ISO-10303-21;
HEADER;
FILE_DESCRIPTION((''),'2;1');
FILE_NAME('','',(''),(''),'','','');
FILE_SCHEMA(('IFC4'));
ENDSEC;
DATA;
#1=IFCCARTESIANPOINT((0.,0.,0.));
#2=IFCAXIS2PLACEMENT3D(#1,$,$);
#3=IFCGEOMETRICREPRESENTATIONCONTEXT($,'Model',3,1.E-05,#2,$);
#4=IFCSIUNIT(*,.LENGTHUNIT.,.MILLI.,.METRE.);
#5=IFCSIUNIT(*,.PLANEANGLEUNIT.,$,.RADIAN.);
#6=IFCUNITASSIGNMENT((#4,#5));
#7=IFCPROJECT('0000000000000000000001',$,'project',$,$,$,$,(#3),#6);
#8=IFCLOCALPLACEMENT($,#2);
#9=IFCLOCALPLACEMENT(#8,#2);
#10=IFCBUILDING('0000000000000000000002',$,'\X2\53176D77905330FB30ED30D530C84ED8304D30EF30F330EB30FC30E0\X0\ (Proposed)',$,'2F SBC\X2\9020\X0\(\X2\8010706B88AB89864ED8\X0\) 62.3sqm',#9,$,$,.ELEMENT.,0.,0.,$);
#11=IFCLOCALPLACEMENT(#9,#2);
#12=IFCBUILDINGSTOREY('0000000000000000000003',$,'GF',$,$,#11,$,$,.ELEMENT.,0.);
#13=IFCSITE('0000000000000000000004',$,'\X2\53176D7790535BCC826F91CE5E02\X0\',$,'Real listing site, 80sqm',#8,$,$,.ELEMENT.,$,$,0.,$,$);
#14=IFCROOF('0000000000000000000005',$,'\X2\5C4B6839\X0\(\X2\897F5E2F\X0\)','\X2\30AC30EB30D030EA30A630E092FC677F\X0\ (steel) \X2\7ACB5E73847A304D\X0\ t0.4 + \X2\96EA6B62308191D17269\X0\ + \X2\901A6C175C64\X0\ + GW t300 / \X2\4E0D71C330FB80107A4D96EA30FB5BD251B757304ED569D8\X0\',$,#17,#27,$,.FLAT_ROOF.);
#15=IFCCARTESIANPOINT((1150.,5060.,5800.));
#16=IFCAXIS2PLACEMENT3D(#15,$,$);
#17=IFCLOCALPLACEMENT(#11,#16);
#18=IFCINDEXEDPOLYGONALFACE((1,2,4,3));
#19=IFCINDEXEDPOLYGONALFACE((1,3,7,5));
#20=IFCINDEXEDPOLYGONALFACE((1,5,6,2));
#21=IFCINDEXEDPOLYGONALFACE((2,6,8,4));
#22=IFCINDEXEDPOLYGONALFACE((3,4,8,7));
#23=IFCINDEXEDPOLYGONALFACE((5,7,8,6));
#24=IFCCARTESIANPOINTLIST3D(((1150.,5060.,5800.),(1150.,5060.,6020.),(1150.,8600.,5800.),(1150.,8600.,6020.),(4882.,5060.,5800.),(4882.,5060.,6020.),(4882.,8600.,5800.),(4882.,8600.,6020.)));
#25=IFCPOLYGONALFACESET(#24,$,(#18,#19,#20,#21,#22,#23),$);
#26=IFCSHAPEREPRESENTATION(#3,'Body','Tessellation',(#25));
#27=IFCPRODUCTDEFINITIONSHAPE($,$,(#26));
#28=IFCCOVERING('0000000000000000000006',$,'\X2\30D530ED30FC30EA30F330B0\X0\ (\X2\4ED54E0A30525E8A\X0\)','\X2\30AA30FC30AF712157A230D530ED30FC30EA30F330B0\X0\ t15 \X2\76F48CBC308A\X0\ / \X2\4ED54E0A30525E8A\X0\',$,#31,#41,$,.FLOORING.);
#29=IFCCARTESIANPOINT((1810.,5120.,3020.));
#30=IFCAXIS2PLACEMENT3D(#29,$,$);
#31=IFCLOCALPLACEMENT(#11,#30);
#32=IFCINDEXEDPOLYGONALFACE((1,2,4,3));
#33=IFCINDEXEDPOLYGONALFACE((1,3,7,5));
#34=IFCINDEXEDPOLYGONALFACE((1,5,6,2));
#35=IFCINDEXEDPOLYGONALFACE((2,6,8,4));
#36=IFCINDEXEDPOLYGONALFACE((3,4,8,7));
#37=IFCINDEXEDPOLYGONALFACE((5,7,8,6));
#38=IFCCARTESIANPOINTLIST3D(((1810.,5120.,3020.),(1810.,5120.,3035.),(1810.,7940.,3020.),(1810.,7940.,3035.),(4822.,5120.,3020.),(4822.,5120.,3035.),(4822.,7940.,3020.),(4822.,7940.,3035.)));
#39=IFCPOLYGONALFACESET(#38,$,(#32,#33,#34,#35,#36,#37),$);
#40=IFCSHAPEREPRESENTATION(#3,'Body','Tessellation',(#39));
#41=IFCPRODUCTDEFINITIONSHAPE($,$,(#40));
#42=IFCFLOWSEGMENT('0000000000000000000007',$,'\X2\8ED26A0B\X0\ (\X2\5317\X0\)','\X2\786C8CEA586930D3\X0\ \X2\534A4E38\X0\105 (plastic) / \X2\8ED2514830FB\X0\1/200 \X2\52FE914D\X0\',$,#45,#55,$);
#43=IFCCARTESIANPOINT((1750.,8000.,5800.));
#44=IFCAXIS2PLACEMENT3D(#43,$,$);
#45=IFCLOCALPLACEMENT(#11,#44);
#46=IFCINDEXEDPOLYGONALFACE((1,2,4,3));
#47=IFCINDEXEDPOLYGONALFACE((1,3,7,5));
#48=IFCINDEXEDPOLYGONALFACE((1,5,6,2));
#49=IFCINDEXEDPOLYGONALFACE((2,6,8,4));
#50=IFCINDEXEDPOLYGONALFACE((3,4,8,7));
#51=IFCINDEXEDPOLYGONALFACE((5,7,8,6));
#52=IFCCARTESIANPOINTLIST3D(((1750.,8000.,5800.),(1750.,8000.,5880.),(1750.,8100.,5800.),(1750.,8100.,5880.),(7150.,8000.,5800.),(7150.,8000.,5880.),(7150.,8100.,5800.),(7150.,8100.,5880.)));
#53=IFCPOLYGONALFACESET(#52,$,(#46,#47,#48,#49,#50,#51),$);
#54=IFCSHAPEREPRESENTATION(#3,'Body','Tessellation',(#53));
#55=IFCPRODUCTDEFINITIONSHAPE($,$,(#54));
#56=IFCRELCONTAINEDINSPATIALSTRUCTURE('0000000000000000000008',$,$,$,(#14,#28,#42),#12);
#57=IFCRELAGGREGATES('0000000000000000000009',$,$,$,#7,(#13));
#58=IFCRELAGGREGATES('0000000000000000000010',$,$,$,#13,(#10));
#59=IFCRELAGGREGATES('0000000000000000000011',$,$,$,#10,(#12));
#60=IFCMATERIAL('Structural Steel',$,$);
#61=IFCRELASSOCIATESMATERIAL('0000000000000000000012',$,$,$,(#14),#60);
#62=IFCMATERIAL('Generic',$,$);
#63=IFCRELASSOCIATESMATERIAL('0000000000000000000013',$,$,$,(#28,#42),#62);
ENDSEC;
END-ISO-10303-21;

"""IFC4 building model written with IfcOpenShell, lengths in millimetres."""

from ifc_helpers import new_model, si_unit, frame, frame_2d, origin, place, context, project, spatial, rectangle, extrude, material, element, save


model = new_model("IFC4")

# Units and contexts
model_context = context("Model", 3, precision=1e-05, world=origin())
ifc_project = project(units=[si_unit("LENGTHUNIT", "METRE", prefix="MILLI"), si_unit("PLANEANGLEUNIT", "RADIAN")], contexts=[model_context])

# Site, building, storey
site_placement = place(None, origin())
site = spatial("IfcSite", under=ifc_project, at=site_placement, Name="北海道富良野市", ObjectType="Real listing site, 80sqm", CompositionType="ELEMENT", RefElevation=0.0)
building_placement = place(site_placement, origin())
building = spatial("IfcBuilding", under=site, at=building_placement, Name="北海道・ロフト付きワンルーム (Proposed)", ObjectType="2F SBC造(耐火被覆付) 62.3sqm", CompositionType="ELEMENT", ElevationOfRefHeight=0.0, ElevationOfTerrain=0.0)
storey_placement = place(building_placement, origin())
storey = spatial("IfcBuildingStorey", under=building, at=storey_placement, Name="GF", CompositionType="ELEMENT", Elevation=0.0)

# Roof
ifc_material_1 = material(Name="Structural Steel")
for number, where, name in (
    (1, (1150.0, 5060.0, 5800.0), "屋根(西帯)"),
):
    element("IfcRoof", number, at=place(storey_placement, frame(where)), inside=storey, material=ifc_material_1, Name=name, Description="ガルバリウム鋼板 (steel) 立平葺き t0.4 + 雪止め金物 + 通気層 + GW t300 / 不燃・耐積雪・寒冷地仕様", PredefinedType="FLAT_ROOF", context=model_context, shape_type="SweptSolid", body=[
        extrude(rectangle(XDim=3732.0, YDim=3540.0, at=frame_2d((1866.0, 1770.0))), frame((1150.0, 5060.0, 5800.0)), (0.0, 0.0, 1.0), 220.0),
    ])

# Covering
ifc_material_2 = material(Name="Generic")
covering_placement = place(storey_placement, frame((1810.0, 5120.0, 3020.0)))
element("IfcCovering", 2, at=covering_placement, inside=storey, material=ifc_material_2, Name="フローリング (仕上げ床)", Description="オーク無垢フローリング t15 直貼り / 仕上げ床", PredefinedType="FLOORING", context=model_context, shape_type="SweptSolid", body=[
    extrude(rectangle(XDim=3012.0, YDim=2820.0, at=frame_2d((1506.0, 1410.0))), frame((1810.0, 5120.0, 3020.0)), (0.0, 0.0, 1.0), 15.0),
])

# Flow segment
flow_segment_placement = place(storey_placement, frame((1750.0, 8000.0, 5800.0)))
element("IfcFlowSegment", 3, at=flow_segment_placement, inside=storey, material=ifc_material_2, Name="軒樋 (北)", Description="硬質塩ビ 半丸105 (plastic) / 軒先・1/200 勾配", context=model_context, shape_type="SweptSolid", body=[
    extrude(rectangle(XDim=5400.0, YDim=100.0, at=frame_2d((2700.0, 50.0))), frame((1750.0, 8000.0, 5800.0)), (0.0, 0.0, 1.0), 80.0),
])

save(model, "model.ifc")
